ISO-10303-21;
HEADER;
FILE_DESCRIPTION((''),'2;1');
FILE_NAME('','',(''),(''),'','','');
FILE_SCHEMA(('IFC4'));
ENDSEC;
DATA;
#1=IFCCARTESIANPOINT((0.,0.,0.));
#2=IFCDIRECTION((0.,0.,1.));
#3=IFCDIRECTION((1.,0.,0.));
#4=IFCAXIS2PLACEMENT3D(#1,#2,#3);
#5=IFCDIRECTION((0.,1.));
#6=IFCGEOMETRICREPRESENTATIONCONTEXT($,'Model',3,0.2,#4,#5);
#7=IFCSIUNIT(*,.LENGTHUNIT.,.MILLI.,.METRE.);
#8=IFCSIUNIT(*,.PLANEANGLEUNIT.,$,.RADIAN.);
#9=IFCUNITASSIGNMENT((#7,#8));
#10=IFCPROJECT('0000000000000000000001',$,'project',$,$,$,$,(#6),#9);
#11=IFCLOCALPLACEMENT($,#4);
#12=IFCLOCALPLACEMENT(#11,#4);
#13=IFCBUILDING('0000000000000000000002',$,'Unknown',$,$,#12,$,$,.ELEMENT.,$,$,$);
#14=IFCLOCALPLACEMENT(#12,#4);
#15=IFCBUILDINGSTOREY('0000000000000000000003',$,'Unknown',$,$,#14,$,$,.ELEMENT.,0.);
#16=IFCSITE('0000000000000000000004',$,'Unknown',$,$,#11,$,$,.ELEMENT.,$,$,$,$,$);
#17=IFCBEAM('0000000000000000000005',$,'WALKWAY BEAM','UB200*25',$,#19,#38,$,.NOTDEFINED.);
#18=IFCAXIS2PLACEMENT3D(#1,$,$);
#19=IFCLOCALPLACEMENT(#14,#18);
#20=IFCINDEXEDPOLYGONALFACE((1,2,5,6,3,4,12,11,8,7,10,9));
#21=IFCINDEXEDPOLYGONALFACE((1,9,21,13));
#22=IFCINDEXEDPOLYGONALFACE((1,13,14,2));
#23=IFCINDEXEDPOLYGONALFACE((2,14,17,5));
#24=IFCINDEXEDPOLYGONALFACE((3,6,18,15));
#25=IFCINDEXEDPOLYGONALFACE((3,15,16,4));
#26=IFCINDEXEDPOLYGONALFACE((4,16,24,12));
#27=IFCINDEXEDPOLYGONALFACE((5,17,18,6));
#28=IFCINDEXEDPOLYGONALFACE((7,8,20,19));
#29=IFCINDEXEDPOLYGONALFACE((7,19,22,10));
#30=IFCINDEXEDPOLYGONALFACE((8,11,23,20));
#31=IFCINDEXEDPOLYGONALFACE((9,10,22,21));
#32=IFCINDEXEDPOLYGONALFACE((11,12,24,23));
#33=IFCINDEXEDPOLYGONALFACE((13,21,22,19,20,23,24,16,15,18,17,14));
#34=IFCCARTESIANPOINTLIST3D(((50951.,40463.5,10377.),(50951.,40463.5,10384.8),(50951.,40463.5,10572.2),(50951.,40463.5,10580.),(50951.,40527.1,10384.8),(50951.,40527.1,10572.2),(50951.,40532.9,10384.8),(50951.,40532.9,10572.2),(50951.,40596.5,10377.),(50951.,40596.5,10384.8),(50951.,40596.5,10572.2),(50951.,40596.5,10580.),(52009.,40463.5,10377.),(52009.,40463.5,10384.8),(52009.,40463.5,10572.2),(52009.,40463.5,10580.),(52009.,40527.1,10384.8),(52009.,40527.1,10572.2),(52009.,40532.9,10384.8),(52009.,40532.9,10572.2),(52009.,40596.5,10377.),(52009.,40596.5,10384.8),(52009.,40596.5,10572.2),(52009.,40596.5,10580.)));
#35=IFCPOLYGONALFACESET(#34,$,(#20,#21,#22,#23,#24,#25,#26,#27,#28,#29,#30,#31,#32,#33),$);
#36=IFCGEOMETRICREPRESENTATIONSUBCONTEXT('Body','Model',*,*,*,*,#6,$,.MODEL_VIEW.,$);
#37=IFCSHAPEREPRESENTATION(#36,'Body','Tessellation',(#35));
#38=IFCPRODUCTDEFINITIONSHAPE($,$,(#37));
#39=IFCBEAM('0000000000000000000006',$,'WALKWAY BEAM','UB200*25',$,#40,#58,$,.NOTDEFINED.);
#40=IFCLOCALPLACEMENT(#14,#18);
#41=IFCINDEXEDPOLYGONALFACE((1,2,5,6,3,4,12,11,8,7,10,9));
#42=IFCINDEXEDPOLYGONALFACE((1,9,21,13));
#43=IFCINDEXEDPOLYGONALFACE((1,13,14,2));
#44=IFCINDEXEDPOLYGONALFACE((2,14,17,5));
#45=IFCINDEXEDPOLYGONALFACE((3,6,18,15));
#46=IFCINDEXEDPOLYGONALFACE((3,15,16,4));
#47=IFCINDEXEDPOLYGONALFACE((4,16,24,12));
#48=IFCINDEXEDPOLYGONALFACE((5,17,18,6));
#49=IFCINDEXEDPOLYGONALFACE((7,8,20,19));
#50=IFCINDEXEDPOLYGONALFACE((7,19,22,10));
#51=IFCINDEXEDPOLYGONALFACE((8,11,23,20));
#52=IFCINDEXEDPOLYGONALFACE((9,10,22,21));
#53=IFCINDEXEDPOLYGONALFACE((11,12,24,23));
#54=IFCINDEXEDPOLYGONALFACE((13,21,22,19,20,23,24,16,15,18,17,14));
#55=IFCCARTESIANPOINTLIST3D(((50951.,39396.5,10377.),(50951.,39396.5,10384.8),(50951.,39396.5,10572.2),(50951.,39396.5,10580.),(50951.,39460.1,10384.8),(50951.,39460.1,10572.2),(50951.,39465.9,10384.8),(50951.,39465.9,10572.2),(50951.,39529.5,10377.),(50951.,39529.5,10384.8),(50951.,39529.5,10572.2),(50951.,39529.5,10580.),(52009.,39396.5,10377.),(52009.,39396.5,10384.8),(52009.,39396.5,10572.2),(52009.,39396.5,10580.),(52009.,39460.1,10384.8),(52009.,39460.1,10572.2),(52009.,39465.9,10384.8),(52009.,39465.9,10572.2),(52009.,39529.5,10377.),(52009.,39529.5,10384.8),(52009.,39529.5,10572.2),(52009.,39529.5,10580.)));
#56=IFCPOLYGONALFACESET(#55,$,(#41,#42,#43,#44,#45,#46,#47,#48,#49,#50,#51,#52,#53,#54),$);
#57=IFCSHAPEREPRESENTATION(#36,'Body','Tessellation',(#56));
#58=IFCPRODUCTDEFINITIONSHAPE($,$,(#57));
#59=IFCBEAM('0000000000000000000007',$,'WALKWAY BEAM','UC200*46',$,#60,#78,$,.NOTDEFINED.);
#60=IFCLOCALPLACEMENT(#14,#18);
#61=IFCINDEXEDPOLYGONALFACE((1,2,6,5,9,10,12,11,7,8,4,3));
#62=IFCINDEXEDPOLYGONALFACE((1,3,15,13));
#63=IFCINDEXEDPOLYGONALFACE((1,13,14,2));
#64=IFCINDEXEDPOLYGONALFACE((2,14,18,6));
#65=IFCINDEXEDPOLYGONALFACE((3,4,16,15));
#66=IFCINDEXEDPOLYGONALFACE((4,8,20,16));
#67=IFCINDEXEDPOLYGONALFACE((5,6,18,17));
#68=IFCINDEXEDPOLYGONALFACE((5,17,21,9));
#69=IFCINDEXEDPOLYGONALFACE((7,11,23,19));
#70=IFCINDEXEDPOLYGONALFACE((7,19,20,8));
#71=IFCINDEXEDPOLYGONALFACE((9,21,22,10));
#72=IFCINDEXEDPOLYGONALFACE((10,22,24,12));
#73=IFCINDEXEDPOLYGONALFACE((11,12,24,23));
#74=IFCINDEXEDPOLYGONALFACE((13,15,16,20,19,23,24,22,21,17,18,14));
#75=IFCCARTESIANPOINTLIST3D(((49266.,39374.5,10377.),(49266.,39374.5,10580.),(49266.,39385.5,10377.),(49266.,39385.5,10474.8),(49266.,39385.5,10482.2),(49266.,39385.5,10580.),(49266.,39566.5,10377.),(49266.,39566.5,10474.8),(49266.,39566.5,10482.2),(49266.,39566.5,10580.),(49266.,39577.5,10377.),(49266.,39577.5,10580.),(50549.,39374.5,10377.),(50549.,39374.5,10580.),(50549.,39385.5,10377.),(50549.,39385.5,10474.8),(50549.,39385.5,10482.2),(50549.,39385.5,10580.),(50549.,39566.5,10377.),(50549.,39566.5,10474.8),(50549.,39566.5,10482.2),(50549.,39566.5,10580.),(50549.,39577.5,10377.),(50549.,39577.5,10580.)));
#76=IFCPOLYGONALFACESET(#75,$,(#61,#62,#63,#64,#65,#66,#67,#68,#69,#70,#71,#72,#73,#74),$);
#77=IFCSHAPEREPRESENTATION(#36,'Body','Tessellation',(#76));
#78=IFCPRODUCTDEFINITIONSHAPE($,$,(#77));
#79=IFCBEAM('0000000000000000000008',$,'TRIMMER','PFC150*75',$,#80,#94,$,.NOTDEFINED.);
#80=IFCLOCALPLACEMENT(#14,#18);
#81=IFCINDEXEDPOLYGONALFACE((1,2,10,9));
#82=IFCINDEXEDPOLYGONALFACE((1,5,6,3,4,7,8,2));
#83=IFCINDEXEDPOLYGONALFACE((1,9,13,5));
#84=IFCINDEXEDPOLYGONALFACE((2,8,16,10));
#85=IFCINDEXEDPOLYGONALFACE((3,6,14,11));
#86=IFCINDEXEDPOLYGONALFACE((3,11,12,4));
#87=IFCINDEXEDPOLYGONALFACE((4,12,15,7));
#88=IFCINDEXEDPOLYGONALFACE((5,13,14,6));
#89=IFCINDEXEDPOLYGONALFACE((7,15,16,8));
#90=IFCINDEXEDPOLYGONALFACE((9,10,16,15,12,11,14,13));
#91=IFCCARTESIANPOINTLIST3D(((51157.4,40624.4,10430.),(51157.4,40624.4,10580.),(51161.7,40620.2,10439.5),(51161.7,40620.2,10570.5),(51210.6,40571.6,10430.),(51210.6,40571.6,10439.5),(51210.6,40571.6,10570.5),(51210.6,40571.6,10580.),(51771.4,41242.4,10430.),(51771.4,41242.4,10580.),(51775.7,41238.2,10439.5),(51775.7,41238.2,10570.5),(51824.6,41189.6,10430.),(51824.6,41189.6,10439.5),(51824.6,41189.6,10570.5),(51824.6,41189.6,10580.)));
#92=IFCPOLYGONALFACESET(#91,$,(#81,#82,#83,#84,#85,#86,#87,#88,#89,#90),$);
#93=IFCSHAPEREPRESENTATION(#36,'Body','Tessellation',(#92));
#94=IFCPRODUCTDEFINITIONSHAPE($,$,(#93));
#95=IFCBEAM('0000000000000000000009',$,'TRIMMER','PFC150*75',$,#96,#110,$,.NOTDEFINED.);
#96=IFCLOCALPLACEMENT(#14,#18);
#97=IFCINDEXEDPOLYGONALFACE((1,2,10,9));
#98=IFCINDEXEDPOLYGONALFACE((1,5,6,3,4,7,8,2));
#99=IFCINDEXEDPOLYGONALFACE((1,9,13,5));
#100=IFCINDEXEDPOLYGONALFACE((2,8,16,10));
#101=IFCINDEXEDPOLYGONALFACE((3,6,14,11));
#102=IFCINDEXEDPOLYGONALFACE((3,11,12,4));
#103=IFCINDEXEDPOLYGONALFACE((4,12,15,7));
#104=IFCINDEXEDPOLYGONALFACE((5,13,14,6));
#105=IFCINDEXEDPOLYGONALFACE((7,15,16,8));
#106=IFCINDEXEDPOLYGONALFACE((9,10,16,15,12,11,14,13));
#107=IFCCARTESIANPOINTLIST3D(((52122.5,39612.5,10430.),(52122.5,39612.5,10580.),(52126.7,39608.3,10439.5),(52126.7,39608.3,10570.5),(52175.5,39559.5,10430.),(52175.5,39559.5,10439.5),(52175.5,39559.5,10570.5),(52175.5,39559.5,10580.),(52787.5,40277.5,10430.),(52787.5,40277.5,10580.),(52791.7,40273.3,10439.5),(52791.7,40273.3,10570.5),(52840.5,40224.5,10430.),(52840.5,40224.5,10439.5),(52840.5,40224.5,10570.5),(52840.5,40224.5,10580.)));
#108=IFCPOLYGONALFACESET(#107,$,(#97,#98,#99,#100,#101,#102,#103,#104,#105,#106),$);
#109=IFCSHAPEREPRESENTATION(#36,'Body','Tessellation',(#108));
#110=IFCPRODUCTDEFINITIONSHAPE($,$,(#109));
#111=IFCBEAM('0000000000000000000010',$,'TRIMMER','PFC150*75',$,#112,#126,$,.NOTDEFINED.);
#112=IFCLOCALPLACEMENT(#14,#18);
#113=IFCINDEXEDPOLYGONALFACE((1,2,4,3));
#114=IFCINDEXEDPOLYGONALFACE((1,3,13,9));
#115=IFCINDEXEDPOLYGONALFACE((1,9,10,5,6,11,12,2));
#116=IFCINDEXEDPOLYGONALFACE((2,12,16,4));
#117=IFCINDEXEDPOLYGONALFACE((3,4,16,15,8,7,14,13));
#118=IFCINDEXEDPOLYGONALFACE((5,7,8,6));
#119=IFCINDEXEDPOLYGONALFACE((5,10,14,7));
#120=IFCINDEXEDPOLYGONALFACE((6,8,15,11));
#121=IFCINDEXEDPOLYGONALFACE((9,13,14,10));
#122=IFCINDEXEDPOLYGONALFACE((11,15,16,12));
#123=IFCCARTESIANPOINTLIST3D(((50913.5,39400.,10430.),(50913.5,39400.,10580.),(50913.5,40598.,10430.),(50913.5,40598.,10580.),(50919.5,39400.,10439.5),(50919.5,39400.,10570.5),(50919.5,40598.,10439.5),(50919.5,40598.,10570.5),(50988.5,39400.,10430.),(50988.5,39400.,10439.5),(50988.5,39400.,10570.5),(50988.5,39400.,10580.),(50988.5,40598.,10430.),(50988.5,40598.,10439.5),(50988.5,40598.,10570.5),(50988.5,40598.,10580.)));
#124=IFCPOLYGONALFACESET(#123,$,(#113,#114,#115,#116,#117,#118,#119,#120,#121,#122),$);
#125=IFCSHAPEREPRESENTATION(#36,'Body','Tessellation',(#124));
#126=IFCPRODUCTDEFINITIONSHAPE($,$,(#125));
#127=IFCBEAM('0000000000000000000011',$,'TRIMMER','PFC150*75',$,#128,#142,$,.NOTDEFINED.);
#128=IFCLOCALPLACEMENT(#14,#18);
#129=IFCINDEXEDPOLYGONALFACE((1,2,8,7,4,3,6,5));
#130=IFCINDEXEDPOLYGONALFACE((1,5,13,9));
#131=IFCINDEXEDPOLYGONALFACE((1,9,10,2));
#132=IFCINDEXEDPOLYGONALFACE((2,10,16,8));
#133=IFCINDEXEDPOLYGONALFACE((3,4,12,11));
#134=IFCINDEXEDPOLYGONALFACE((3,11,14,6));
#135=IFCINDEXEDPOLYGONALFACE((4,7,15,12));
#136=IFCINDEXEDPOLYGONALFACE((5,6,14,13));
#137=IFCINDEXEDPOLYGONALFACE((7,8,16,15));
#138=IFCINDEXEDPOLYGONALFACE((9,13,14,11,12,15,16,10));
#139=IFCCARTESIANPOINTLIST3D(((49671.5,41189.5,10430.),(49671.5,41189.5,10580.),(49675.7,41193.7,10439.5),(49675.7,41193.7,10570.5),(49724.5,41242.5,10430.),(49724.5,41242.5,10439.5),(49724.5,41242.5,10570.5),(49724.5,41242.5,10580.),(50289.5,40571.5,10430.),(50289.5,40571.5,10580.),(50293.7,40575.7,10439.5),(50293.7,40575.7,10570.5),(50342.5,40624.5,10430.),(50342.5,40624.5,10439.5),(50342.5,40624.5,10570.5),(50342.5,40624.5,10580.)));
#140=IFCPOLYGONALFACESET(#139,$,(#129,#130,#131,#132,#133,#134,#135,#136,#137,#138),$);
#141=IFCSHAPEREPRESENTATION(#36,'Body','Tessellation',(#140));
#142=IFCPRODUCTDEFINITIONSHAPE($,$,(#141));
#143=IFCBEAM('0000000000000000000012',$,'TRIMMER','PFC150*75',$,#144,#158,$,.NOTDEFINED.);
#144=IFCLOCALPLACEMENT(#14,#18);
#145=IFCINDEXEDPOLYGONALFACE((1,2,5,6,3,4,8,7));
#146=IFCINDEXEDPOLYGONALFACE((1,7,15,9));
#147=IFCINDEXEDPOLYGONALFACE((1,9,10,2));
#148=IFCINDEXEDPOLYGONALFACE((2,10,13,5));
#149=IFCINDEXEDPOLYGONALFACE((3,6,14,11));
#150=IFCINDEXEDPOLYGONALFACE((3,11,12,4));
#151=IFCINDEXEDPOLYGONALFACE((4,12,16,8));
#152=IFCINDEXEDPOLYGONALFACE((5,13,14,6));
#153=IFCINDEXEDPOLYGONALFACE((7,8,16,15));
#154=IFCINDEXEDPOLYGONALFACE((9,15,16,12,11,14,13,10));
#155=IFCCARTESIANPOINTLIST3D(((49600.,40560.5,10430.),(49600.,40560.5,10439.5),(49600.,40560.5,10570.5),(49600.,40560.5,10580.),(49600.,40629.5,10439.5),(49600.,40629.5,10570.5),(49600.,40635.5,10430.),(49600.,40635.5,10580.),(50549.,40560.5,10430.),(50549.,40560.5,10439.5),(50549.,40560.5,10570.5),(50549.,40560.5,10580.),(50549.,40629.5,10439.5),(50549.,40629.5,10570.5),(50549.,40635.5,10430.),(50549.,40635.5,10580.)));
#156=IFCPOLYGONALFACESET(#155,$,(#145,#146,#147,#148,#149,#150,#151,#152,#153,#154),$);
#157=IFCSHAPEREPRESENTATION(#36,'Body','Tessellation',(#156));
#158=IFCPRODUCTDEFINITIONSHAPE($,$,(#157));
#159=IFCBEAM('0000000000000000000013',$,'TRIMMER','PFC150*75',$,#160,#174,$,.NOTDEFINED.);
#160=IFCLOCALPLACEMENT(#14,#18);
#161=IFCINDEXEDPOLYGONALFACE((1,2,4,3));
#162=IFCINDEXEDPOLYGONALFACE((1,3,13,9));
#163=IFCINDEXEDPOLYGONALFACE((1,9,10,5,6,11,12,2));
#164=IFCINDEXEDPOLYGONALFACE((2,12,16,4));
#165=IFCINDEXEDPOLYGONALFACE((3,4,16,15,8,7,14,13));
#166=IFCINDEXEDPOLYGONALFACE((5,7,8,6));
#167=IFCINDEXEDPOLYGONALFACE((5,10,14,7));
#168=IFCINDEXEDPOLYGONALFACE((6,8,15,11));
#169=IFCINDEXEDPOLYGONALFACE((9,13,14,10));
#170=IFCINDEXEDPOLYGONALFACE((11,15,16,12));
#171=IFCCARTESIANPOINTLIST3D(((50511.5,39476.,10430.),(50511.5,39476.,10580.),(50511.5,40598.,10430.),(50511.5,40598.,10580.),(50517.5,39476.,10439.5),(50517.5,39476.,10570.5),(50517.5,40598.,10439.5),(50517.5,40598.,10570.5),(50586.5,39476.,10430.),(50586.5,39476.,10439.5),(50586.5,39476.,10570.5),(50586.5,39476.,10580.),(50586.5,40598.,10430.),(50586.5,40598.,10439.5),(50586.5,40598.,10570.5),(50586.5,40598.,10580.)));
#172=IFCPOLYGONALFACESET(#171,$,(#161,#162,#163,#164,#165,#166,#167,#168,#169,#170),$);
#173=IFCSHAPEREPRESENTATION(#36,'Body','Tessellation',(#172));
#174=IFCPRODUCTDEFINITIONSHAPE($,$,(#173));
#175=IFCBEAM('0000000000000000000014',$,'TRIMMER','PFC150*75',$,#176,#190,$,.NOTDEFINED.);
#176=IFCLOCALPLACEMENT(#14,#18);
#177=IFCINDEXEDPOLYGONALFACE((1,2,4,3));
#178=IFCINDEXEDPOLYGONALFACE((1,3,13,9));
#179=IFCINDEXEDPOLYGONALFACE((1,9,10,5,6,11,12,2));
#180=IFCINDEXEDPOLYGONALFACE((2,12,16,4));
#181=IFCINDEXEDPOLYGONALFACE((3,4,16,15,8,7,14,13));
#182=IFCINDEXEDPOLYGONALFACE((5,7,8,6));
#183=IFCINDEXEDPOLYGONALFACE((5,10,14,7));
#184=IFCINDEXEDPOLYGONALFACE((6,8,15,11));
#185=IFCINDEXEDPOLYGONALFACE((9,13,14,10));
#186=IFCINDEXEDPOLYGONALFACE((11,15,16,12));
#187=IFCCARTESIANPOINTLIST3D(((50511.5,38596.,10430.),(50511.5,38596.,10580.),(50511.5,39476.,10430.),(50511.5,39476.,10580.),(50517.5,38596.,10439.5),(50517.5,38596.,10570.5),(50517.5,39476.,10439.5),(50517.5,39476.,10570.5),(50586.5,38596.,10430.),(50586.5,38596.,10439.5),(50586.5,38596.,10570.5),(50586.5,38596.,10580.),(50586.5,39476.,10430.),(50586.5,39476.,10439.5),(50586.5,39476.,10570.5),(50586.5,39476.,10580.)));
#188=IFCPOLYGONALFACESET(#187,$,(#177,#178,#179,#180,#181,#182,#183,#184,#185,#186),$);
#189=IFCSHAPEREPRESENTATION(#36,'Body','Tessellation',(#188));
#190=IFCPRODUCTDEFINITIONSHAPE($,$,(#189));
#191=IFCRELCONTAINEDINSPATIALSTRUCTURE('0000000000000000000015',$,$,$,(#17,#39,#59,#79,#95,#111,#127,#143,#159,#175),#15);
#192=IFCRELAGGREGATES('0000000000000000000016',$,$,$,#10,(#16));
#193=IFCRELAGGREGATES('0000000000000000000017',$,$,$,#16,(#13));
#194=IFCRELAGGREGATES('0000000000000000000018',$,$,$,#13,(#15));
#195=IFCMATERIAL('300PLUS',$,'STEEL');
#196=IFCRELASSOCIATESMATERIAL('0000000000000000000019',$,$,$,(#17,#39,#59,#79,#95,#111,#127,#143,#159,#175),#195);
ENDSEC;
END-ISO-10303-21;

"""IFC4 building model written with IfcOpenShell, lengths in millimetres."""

from ifc_helpers import new_model, si_unit, direction, frame, origin_with_axes, place, context, subcontext, project, spatial, line, indexed_curve, outline, extrude, material, element, save


model = new_model("IFC4")

# Units and contexts
model_context = context("Model", 3, precision=0.2, world=origin_with_axes(), true_north=direction((0.0, 1.0)))
body_context = subcontext(model_context, "Body", "Model", "MODEL_VIEW")
ifc_project = project(units=[si_unit("LENGTHUNIT", "METRE", prefix="MILLI"), si_unit("PLANEANGLEUNIT", "RADIAN")], contexts=[model_context])

# Site, building, storey
site_placement = place(None, origin_with_axes())
site = spatial("IfcSite", under=ifc_project, at=site_placement, Name="Unknown", CompositionType="ELEMENT")
building_placement = place(site_placement, origin_with_axes())
building = spatial("IfcBuilding", under=site, at=building_placement, Name="Unknown", CompositionType="ELEMENT")
storey_placement = place(building_placement, origin_with_axes())
storey = spatial("IfcBuildingStorey", under=building, at=storey_placement, Name="Unknown", CompositionType="ELEMENT", Elevation=0.0)

# Beams
ifc_material_1 = material(Name="300PLUS", Category="STEEL")
for number, where, z_axis, x_axis, name in (
    (1, (50951.0, 40530.0, 10478.5), (0.0, -1.0, 0.0), (1.0, 0.0, 0.0), "WALKWAY BEAM"),
    (2, (50951.0, 39463.0, 10478.5), (0.0, -1.0, 0.0), (1.0, 0.0, 0.0), "WALKWAY BEAM"),
):
    element("IfcBeam", number, at=place(storey_placement, frame(where, z_axis=z_axis, x_axis=x_axis)), inside=storey, material=ifc_material_1, Name=name, Description="UB200*25", PredefinedType="NOTDEFINED", context=body_context, shape_type="SolidModel", body=[
        extrude(outline(indexed_curve([(-66.5, -101.5), (66.5, -101.5), (66.5, -93.7), (2.9, -93.7), (2.9, 93.7), (66.5, 93.7), (66.5, 101.5), (-66.5, 101.5), (-66.5, 93.7), (-2.9, 93.7), (-2.9, -93.7), (-66.5, -93.7)], segments=[line(1, 2, 3, 4, 5, 6, 7, 8, 9, 10, 11, 12, 1)])), frame((0.0, 0.0, 0.0), z_axis=(-1.0, 0.0, 0.0), x_axis=(0.0, 0.0, 1.0)), (0.0, 0.0, -1.0), 1058.0),
    ])
beam_1_placement = place(storey_placement, frame((49266.0, 39476.0, 10478.5), z_axis=(0.0, 0.0, 1.0), x_axis=(1.0, 0.0, 0.0)))
element("IfcBeam", 3, at=beam_1_placement, inside=storey, material=ifc_material_1, Name="WALKWAY BEAM", Description="UC200*46", PredefinedType="NOTDEFINED", context=body_context, shape_type="SolidModel", body=[
    extrude(outline(indexed_curve([(-101.5, -101.5), (101.5, -101.5), (101.5, -90.5), (3.6, -90.5), (3.6, 90.5), (101.5, 90.5), (101.5, 101.5), (-101.5, 101.5), (-101.5, 90.5), (-3.6, 90.5), (-3.6, -90.5), (-101.5, -90.5)], segments=[line(1, 2, 3, 4, 5, 6, 7, 8, 9, 10, 11, 12, 1)])), frame((0.0, 0.0, 0.0), z_axis=(-1.0, 0.0, 0.0), x_axis=(0.0, 0.0, 1.0)), (0.0, 0.0, -1.0), 1283.0),
])
beam_2_placement = place(storey_placement, frame((51184.0, 40598.0, 10505.0), z_axis=(0.709399, -0.704807, 0.0), x_axis=(0.704807, 0.709399, 0.0)))
element("IfcBeam", 4, at=beam_2_placement, inside=storey, material=ifc_material_1, Name="TRIMMER", Description="PFC150*75", PredefinedType="NOTDEFINED", context=body_context, shape_type="SolidModel", body=[
    extrude(outline(indexed_curve([(-37.5, -75.0), (37.5, -75.0), (37.5, -65.5), (-31.5, -65.5), (-31.5, 65.5), (37.5, 65.5), (37.5, 75.0), (-37.5, 75.0)], segments=[line(1, 2, 3, 4, 5, 6, 7, 8, 1)])), frame((0.0, 0.0, 0.0), z_axis=(-1.0, 0.0, 0.0), x_axis=(0.0, 0.0, 1.0)), (0.0, 0.0, -1.0), 871.2),
])
beam_3_placement = place(storey_placement, frame((52149.0, 39586.0, 10505.0), z_axis=(0.707107, -0.707107, 0.0), x_axis=(0.707107, 0.707107, 0.0)))
element("IfcBeam", 5, at=beam_3_placement, inside=storey, material=ifc_material_1, Name="TRIMMER", Description="PFC150*75", PredefinedType="NOTDEFINED", context=body_context, shape_type="SolidModel", body=[
    extrude(outline(indexed_curve([(-37.5, -75.0), (37.5, -75.0), (37.5, -65.5), (-31.5, -65.5), (-31.5, 65.5), (37.5, 65.5), (37.5, 75.0), (-37.5, 75.0)], segments=[line(1, 2, 3, 4, 5, 6, 7, 8, 1)])), frame((0.0, 0.0, 0.0), z_axis=(-1.0, 0.0, 0.0), x_axis=(0.0, 0.0, 1.0)), (0.0, 0.0, -1.0), 940.5),
])
beam_4_placement = place(storey_placement, frame((50951.0, 39400.0, 10505.0), z_axis=(1.0, 0.0, 0.0), x_axis=(0.0, 1.0, 0.0)))
element("IfcBeam", 6, at=beam_4_placement, inside=storey, material=ifc_material_1, Name="TRIMMER", Description="PFC150*75", PredefinedType="NOTDEFINED", context=body_context, shape_type="SolidModel", body=[
    extrude(outline(indexed_curve([(-37.5, -75.0), (37.5, -75.0), (37.5, -65.5), (-31.5, -65.5), (-31.5, 65.5), (37.5, 65.5), (37.5, 75.0), (-37.5, 75.0)], segments=[line(1, 2, 3, 4, 5, 6, 7, 8, 1)])), frame((0.0, 0.0, 0.0), z_axis=(-1.0, 0.0, 0.0), x_axis=(0.0, 0.0, 1.0)), (0.0, 0.0, -1.0), 1198.0),
])
beam_5_placement = place(storey_placement, frame((50316.0, 40598.0, 10505.0), z_axis=(0.707107, 0.707107, 0.0), x_axis=(-0.707107, 0.707107, 0.0)))
element("IfcBeam", 7, at=beam_5_placement, inside=storey, material=ifc_material_1, Name="TRIMMER", Description="PFC150*75", PredefinedType="NOTDEFINED", context=body_context, shape_type="SolidModel", body=[
    extrude(outline(indexed_curve([(-37.5, -75.0), (37.5, -75.0), (37.5, -65.5), (-31.5, -65.5), (-31.5, 65.5), (37.5, 65.5), (37.5, 75.0), (-37.5, 75.0)], segments=[line(1, 2, 3, 4, 5, 6, 7, 8, 1)])), frame((0.0, 0.0, 0.0), z_axis=(-1.0, 0.0, 0.0), x_axis=(0.0, 0.0, 1.0)), (0.0, 0.0, -1.0), 874.0),
])
beam_6_placement = place(storey_placement, frame((49600.0, 40598.0, 10505.0), z_axis=(0.0, -1.0, 0.0), x_axis=(1.0, 0.0, 0.0)))
element("IfcBeam", 8, at=beam_6_placement, inside=storey, material=ifc_material_1, Name="TRIMMER", Description="PFC150*75", PredefinedType="NOTDEFINED", context=body_context, shape_type="SolidModel", body=[
    extrude(outline(indexed_curve([(-37.5, -75.0), (37.5, -75.0), (37.5, -65.5), (-31.5, -65.5), (-31.5, 65.5), (37.5, 65.5), (37.5, 75.0), (-37.5, 75.0)], segments=[line(1, 2, 3, 4, 5, 6, 7, 8, 1)])), frame((0.0, 0.0, 0.0), z_axis=(-1.0, 0.0, 0.0), x_axis=(0.0, 0.0, 1.0)), (0.0, 0.0, -1.0), 949.0),
])
beam_7_placement = place(storey_placement, frame((50549.0, 39476.0, 10505.0), z_axis=(1.0, 0.0, 0.0), x_axis=(0.0, 1.0, 0.0)))
element("IfcBeam", 9, at=beam_7_placement, inside=storey, material=ifc_material_1, Name="TRIMMER", Description="PFC150*75", PredefinedType="NOTDEFINED", context=body_context, shape_type="SolidModel", body=[
    extrude(outline(indexed_curve([(-37.5, -75.0), (37.5, -75.0), (37.5, -65.5), (-31.5, -65.5), (-31.5, 65.5), (37.5, 65.5), (37.5, 75.0), (-37.5, 75.0)], segments=[line(1, 2, 3, 4, 5, 6, 7, 8, 1)])), frame((0.0, 0.0, 0.0), z_axis=(-1.0, 0.0, 0.0), x_axis=(0.0, 0.0, 1.0)), (0.0, 0.0, -1.0), 1122.0),
])
for number, where, z_axis, x_axis, name in (
    (10, (50549.0, 38596.0, 10505.0), (1.0, 0.0, 0.0), (0.0, 1.0, 0.0), "TRIMMER"),
):
    element("IfcBeam", number, at=place(storey_placement, frame(where, z_axis=z_axis, x_axis=x_axis)), inside=storey, material=ifc_material_1, Name=name, Description="PFC150*75", PredefinedType="NOTDEFINED", context=body_context, shape_type="SolidModel", body=[
        extrude(outline(indexed_curve([(-37.5, -75.0), (37.5, -75.0), (37.5, -65.5), (-31.5, -65.5), (-31.5, 65.5), (37.5, 65.5), (37.5, 75.0), (-37.5, 75.0)], segments=[line(1, 2, 3, 4, 5, 6, 7, 8, 1)])), frame((0.0, 0.0, 0.0), z_axis=(-1.0, 0.0, 0.0), x_axis=(0.0, 0.0, 1.0)), (0.0, 0.0, -1.0), 880.0),
    ])

save(model, "model.ifc")
